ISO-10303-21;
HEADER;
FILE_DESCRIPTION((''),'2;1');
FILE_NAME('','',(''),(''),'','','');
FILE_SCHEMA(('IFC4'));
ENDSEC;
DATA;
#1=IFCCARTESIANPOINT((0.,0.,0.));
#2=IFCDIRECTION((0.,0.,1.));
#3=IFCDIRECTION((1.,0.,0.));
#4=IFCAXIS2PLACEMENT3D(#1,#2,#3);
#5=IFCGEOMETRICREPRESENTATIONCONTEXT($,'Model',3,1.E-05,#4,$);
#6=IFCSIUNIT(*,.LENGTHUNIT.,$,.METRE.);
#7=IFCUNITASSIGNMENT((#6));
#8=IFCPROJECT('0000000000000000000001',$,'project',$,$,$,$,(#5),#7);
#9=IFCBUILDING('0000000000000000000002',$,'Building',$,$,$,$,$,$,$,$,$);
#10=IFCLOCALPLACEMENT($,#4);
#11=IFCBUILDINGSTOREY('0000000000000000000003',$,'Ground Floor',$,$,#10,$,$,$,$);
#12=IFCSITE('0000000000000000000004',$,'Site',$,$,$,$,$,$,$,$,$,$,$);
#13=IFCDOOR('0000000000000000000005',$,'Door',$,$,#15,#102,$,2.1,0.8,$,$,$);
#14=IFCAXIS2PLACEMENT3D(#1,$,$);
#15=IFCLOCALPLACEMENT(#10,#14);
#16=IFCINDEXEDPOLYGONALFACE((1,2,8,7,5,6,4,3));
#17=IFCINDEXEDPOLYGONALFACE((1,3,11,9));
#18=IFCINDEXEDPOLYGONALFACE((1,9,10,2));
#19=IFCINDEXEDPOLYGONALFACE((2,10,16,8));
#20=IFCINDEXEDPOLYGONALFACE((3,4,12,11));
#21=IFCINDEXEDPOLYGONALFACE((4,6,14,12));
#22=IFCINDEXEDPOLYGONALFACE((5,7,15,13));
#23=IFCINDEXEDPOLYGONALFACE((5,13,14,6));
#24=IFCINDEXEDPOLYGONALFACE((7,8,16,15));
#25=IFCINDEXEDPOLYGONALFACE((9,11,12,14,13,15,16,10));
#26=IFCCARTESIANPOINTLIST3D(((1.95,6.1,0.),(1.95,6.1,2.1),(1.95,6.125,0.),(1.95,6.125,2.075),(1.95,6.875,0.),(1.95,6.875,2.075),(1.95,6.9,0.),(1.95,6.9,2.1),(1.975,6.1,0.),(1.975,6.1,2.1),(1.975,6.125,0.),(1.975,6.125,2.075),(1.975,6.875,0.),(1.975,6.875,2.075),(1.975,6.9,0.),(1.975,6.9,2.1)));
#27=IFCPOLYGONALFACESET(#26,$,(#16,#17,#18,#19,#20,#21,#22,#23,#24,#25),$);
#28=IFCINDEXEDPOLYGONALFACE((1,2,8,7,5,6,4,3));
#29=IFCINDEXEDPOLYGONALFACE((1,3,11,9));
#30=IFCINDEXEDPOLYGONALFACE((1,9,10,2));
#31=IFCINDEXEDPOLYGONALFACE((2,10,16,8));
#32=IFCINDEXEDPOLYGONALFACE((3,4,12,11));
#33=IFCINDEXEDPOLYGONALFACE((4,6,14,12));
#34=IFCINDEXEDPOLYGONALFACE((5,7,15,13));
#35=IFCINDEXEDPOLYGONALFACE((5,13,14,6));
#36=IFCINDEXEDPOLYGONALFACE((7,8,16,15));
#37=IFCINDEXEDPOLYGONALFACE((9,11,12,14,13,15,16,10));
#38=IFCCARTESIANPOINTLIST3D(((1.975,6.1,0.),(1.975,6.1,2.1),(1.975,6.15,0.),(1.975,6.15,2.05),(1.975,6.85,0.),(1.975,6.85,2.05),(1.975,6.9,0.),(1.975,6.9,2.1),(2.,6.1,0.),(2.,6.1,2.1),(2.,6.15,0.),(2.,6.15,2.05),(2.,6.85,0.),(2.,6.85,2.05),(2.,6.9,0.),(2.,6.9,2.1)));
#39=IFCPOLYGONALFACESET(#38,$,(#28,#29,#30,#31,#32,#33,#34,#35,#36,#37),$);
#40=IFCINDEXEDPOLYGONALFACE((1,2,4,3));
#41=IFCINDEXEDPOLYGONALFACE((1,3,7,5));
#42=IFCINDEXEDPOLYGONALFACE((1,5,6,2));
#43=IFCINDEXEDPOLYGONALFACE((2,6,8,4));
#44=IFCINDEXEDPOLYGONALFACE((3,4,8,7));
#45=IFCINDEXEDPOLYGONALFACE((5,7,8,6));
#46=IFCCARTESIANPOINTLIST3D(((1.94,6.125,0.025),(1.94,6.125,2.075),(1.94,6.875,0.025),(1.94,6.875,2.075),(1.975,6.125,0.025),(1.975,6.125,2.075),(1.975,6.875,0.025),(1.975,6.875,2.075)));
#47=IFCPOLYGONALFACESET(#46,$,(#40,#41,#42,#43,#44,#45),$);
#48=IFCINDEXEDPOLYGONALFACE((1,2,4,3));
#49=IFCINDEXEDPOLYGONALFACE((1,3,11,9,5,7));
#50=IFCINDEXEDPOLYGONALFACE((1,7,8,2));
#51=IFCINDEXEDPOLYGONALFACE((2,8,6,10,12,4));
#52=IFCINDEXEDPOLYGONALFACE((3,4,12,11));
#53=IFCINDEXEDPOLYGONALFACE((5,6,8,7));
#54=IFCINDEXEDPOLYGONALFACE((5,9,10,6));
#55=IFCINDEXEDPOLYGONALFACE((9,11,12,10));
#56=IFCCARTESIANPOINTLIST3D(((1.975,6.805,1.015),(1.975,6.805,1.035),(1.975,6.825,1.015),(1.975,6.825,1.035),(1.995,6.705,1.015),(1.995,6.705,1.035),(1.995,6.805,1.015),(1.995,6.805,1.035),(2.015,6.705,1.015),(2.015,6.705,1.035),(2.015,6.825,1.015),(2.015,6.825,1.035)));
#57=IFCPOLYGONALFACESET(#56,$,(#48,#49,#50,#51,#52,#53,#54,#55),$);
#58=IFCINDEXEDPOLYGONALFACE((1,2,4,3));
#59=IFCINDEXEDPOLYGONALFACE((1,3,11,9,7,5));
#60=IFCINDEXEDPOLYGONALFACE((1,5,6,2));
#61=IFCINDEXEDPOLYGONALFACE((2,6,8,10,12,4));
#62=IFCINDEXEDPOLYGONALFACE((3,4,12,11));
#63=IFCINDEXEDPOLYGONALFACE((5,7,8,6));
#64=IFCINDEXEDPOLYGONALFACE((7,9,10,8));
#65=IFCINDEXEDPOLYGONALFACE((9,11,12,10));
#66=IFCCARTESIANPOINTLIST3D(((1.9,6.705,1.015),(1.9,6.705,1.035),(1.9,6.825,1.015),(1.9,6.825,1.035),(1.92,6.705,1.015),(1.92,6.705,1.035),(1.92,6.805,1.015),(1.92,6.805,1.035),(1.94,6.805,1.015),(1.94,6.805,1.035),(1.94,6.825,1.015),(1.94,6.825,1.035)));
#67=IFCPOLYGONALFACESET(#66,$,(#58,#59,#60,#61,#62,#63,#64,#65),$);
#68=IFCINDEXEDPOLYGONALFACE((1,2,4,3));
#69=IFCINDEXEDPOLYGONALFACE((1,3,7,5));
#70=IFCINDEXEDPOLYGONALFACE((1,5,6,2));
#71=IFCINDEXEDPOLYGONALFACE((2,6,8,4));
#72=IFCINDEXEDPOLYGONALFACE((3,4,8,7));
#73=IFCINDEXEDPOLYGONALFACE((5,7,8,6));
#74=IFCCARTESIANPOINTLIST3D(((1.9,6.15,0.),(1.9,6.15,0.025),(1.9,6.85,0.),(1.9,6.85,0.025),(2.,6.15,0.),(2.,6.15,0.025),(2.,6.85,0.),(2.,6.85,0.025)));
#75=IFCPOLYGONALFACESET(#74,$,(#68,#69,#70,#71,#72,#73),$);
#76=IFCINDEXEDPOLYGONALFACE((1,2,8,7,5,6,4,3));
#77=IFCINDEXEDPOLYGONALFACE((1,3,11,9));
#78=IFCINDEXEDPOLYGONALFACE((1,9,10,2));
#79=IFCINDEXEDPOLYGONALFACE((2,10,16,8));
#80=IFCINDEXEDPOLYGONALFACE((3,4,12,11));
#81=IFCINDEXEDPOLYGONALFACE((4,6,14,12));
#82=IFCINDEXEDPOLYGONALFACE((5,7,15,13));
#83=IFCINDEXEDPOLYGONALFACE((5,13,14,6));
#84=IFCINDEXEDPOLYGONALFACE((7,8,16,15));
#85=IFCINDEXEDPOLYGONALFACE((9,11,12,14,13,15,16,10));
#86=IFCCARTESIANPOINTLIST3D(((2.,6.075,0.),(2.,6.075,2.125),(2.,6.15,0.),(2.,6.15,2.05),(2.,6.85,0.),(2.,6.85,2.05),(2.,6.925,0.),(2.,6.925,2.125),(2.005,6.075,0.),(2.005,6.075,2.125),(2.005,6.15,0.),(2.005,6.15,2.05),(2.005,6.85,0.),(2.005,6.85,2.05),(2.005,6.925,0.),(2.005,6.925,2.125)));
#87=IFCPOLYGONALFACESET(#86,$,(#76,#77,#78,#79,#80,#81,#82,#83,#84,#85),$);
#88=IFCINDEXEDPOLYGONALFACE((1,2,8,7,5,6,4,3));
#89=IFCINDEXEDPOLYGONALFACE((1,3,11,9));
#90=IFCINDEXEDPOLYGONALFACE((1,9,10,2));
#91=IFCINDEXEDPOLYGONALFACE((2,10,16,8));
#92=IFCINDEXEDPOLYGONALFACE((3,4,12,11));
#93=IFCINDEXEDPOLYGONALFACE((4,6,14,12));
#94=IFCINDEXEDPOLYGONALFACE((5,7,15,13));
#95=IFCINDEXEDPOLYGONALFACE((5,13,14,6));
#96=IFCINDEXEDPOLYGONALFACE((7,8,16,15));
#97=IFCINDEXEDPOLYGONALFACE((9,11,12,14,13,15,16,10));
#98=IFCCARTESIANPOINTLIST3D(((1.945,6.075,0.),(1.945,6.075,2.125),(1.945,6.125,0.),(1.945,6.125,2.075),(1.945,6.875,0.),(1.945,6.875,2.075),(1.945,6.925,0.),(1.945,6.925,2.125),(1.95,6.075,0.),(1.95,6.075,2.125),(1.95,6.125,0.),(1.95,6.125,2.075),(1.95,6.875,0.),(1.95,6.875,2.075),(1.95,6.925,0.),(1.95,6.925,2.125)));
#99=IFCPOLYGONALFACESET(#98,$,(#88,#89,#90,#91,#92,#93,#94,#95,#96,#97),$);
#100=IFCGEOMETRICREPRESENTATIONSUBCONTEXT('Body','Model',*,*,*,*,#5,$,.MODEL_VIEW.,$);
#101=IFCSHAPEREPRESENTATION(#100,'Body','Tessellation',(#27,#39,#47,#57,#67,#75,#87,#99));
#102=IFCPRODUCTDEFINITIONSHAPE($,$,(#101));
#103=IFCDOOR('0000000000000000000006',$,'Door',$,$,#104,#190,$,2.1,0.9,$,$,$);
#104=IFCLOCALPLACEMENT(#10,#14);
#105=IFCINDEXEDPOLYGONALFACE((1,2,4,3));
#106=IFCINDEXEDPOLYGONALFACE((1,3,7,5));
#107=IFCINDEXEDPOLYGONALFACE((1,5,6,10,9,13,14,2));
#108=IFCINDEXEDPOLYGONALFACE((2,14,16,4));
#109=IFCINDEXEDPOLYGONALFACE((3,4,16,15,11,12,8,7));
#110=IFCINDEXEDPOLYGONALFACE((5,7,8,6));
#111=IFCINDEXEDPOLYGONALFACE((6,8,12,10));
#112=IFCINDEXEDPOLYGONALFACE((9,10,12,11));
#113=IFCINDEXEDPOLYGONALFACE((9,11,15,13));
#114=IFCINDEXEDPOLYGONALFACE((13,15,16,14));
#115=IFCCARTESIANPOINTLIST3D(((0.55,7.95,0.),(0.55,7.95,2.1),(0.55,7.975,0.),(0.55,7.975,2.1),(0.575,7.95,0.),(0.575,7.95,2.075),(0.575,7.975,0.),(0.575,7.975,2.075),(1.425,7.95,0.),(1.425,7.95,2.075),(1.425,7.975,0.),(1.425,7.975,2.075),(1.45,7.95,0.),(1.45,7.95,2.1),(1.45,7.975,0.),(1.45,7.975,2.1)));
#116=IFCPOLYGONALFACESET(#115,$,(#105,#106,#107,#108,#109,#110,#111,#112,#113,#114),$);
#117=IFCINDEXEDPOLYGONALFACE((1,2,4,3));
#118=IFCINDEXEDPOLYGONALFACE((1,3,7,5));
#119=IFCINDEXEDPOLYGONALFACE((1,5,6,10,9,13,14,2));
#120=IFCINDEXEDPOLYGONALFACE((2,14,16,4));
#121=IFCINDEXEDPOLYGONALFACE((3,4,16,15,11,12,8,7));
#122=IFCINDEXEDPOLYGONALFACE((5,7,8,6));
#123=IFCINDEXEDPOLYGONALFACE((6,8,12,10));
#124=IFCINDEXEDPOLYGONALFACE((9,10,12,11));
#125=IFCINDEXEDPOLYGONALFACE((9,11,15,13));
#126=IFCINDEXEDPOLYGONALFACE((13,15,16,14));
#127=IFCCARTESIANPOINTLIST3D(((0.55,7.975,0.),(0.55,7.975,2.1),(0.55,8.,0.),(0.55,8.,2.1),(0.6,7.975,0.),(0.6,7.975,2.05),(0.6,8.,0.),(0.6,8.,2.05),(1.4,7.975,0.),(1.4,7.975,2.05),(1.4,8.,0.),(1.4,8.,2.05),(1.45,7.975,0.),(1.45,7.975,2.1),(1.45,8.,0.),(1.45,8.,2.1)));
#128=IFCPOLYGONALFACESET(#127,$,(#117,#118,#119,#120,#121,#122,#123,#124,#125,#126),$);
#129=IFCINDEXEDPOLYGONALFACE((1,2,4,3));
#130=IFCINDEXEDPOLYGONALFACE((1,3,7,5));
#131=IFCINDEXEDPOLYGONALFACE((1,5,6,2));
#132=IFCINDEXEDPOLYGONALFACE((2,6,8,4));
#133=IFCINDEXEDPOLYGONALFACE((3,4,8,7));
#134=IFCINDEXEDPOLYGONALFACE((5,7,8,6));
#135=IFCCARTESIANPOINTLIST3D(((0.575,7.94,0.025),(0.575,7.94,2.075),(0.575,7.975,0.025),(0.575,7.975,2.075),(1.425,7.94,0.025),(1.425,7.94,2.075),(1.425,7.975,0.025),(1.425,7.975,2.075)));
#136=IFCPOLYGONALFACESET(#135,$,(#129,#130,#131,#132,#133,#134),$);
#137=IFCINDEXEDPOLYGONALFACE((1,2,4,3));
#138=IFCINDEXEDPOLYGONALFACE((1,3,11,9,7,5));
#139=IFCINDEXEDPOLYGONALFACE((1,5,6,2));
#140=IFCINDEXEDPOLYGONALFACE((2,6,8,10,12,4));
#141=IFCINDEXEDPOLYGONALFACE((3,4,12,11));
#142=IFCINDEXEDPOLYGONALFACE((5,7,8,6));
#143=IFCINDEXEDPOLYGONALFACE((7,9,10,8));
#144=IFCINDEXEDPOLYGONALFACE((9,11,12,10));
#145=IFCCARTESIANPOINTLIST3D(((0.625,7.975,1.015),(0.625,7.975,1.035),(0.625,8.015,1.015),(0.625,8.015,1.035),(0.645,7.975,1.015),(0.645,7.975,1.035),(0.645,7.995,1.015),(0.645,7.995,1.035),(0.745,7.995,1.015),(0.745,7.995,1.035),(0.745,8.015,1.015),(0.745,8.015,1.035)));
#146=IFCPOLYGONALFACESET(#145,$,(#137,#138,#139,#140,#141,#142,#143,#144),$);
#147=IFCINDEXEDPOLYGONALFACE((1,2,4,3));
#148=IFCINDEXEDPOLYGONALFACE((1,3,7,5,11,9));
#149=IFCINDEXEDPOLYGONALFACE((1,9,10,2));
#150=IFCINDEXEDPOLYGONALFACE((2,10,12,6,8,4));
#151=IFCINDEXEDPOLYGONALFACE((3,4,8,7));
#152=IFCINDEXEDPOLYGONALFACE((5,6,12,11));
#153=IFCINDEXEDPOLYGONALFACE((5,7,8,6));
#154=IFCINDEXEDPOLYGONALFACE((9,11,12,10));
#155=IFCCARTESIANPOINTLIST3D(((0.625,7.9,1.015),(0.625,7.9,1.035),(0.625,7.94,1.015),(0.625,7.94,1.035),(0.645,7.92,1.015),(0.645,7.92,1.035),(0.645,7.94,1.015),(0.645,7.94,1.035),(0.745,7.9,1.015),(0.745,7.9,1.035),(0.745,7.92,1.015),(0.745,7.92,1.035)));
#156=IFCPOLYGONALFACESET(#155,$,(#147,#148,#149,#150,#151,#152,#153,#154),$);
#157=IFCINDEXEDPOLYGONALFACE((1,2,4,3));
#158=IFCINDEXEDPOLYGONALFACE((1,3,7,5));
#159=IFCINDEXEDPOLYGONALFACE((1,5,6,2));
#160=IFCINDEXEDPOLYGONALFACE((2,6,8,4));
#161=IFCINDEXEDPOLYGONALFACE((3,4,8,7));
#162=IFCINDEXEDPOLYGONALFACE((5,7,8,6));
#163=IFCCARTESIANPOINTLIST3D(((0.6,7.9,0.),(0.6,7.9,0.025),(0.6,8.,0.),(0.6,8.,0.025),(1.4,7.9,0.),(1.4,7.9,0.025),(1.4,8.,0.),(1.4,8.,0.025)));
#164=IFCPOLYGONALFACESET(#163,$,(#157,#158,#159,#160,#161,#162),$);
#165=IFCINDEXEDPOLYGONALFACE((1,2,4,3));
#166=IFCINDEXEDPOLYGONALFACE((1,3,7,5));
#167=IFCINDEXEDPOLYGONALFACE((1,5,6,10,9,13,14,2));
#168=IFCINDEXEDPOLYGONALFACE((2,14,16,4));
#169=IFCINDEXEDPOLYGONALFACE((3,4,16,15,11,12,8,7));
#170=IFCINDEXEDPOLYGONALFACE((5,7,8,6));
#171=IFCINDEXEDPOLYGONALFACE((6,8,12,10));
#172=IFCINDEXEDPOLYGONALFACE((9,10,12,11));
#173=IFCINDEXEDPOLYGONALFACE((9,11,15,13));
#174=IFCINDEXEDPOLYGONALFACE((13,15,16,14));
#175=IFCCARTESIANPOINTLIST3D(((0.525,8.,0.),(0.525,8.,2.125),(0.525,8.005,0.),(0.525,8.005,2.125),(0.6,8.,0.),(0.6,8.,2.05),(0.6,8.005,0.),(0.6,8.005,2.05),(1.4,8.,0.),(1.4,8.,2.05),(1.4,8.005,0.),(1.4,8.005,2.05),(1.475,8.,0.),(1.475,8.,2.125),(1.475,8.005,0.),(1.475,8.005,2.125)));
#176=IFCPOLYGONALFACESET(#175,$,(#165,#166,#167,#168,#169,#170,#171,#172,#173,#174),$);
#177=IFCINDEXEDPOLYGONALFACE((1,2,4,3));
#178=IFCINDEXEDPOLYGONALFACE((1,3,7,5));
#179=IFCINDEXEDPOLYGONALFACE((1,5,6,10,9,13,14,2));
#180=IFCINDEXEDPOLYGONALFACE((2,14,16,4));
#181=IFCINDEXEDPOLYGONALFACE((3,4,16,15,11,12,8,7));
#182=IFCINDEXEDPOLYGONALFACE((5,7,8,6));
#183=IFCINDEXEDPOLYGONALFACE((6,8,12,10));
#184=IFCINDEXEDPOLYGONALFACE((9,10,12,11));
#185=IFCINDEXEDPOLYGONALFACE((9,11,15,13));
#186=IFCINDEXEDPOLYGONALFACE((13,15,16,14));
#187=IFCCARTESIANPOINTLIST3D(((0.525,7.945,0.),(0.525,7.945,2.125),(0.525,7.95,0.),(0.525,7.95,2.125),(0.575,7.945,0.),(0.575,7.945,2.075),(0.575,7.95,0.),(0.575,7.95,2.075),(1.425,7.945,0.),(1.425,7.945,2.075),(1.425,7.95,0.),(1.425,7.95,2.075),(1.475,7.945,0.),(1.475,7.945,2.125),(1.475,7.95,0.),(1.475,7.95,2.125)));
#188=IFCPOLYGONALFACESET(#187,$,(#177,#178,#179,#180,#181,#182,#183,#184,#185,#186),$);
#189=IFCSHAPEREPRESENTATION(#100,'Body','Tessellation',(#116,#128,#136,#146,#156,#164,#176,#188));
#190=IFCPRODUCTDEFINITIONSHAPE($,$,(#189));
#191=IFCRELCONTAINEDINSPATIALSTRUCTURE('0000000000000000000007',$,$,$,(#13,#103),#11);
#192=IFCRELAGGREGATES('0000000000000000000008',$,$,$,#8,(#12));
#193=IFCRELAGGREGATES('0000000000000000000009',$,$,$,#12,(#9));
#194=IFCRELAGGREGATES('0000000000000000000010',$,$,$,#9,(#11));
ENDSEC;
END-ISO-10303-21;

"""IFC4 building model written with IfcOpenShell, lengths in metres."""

from ifc_helpers import new_model, si_unit, frame, origin_with_axes, place, context, subcontext, project, spatial, line, indexed_curve, outline, extrude, element, save


model = new_model("IFC4")

# Units and contexts
model_context = context("Model", 3, precision=1e-05, world=origin_with_axes())
body_context = subcontext(model_context, "Body", "Model", "MODEL_VIEW")
ifc_project = project(units=[si_unit("LENGTHUNIT", "METRE")], contexts=[model_context])

# Site, building, storey
site = spatial("IfcSite", under=ifc_project, Name="Site")
building = spatial("IfcBuilding", under=site, Name="Building")
storey_placement = place(None, origin_with_axes())
storey = spatial("IfcBuildingStorey", under=building, at=storey_placement, Name="Ground Floor")

# Doors
door_1_placement = place(storey_placement, frame((2.0, 6.1, 0.0), z_axis=(0.0, 0.0, 1.0), x_axis=(0.0, 1.0, 0.0)))
element("IfcDoor", 1, at=door_1_placement, inside=storey, Name="Door", OverallHeight=2.1, OverallWidth=0.8, context=body_context, shape_type="SweptSolid", body=[
    extrude(outline(indexed_curve([(0.0, 0.0), (0.0, 2.1), (0.8, 2.1), (0.8, 0.0), (0.775, 0.0), (0.775, 2.075), (0.025, 2.075), (0.025, 0.0)], segments=[line(1, 2, 3, 4, 5, 6, 7, 8, 1)])), frame((0.0, 0.025, 0.0), z_axis=(0.0, -1.0, 0.0), x_axis=(1.0, 0.0, 0.0)), (0.0, 0.0, -1.0), 0.025),
    extrude(outline(indexed_curve([(0.0, 0.0), (0.0, 2.1), (0.8, 2.1), (0.8, 0.0), (0.75, 0.0), (0.75, 2.05), (0.05, 2.05), (0.05, 0.0)], segments=[line(1, 2, 3, 4, 5, 6, 7, 8, 1)])), frame((0.0, 0.0, 0.0), z_axis=(0.0, -1.0, 0.0), x_axis=(1.0, 0.0, 0.0)), (0.0, 0.0, -1.0), 0.025),
    extrude(outline(indexed_curve([(0.0, 0.0), (0.75, 0.0), (0.75, 0.035), (0.0, 0.035)], segments=[line(1, 2, 3, 4, 1)])), frame((0.025, 0.025, 0.025), z_axis=(0.0, 0.0, 1.0), x_axis=(1.0, 0.0, 0.0)), (0.0, 0.0, 1.0), 2.05),
    extrude(outline(indexed_curve([(0.0, 0.0), (0.0, -0.04), (-0.12, -0.04), (-0.12, -0.02), (-0.02, -0.02), (-0.02, 0.0)], segments=[line(1, 2, 3, 4, 5, 6, 1)])), frame((0.725, 0.025, 1.015), z_axis=(0.0, 0.0, 1.0), x_axis=(1.0, 0.0, 0.0)), (0.0, 0.0, 1.0), 0.02),
    extrude(outline(indexed_curve([(0.0, 0.0), (0.0, 0.04), (-0.12, 0.04), (-0.12, 0.02), (-0.02, 0.02), (-0.02, 0.0)], segments=[line(1, 2, 3, 4, 5, 6, 1)])), frame((0.725, 0.06, 1.015), z_axis=(0.0, 0.0, 1.0), x_axis=(1.0, 0.0, 0.0)), (0.0, 0.0, 1.0), 0.02),
    extrude(outline(indexed_curve([(0.0, 0.0), (0.7, 0.0), (0.7, 0.1), (0.0, 0.1)], segments=[line(1, 2, 3, 4, 1)])), frame((0.05, 0.0, 0.0), z_axis=(0.0, 0.0, 1.0), x_axis=(1.0, 0.0, 0.0)), (0.0, 0.0, 1.0), 0.025),
    extrude(outline(indexed_curve([(0.0, 0.0), (0.0, 2.125), (0.85, 2.125), (0.85, 0.0), (0.775, 0.0), (0.775, 2.05), (0.075, 2.05), (0.075, 0.0)], segments=[line(1, 2, 3, 4, 5, 6, 7, 8, 1)])), frame((-0.025, -0.005, 0.0), z_axis=(0.0, -1.0, 0.0), x_axis=(1.0, 0.0, 0.0)), (0.0, 0.0, -1.0), 0.005),
    extrude(outline(indexed_curve([(0.0, 0.0), (0.0, 2.125), (0.85, 2.125), (0.85, 0.0), (0.8, 0.0), (0.8, 2.075), (0.05, 2.075), (0.05, 0.0)], segments=[line(1, 2, 3, 4, 5, 6, 7, 8, 1)])), frame((-0.025, 0.05, 0.0), z_axis=(0.0, -1.0, 0.0), x_axis=(1.0, 0.0, 0.0)), (0.0, 0.0, -1.0), 0.005),
])
door_2_placement = place(storey_placement, frame((1.45, 8.0, 0.0), z_axis=(0.0, 0.0, 1.0), x_axis=(-1.0, 0.0, 0.0)))
element("IfcDoor", 2, at=door_2_placement, inside=storey, Name="Door", OverallHeight=2.1, OverallWidth=0.9, context=body_context, shape_type="SweptSolid", body=[
    extrude(outline(indexed_curve([(0.0, 0.0), (0.0, 2.1), (0.9, 2.1), (0.9, 0.0), (0.875, 0.0), (0.875, 2.075), (0.025, 2.075), (0.025, 0.0)], segments=[line(1, 2, 3, 4, 5, 6, 7, 8, 1)])), frame((0.0, 0.025, 0.0), z_axis=(0.0, -1.0, 0.0), x_axis=(1.0, 0.0, 0.0)), (0.0, 0.0, -1.0), 0.025),
    extrude(outline(indexed_curve([(0.0, 0.0), (0.0, 2.1), (0.9, 2.1), (0.9, 0.0), (0.85, 0.0), (0.85, 2.05), (0.05, 2.05), (0.05, 0.0)], segments=[line(1, 2, 3, 4, 5, 6, 7, 8, 1)])), frame((0.0, 0.0, 0.0), z_axis=(0.0, -1.0, 0.0), x_axis=(1.0, 0.0, 0.0)), (0.0, 0.0, -1.0), 0.025),
    extrude(outline(indexed_curve([(0.0, 0.0), (0.85, 0.0), (0.85, 0.035), (0.0, 0.035)], segments=[line(1, 2, 3, 4, 1)])), frame((0.025, 0.025, 0.025), z_axis=(0.0, 0.0, 1.0), x_axis=(1.0, 0.0, 0.0)), (0.0, 0.0, 1.0), 2.05),
    extrude(outline(indexed_curve([(0.0, 0.0), (0.0, -0.04), (-0.12, -0.04), (-0.12, -0.02), (-0.02, -0.02), (-0.02, 0.0)], segments=[line(1, 2, 3, 4, 5, 6, 1)])), frame((0.825, 0.025, 1.015), z_axis=(0.0, 0.0, 1.0), x_axis=(1.0, 0.0, 0.0)), (0.0, 0.0, 1.0), 0.02),
    extrude(outline(indexed_curve([(0.0, 0.0), (0.0, 0.04), (-0.12, 0.04), (-0.12, 0.02), (-0.02, 0.02), (-0.02, 0.0)], segments=[line(1, 2, 3, 4, 5, 6, 1)])), frame((0.825, 0.06, 1.015), z_axis=(0.0, 0.0, 1.0), x_axis=(1.0, 0.0, 0.0)), (0.0, 0.0, 1.0), 0.02),
    extrude(outline(indexed_curve([(0.0, 0.0), (0.8, 0.0), (0.8, 0.1), (0.0, 0.1)], segments=[line(1, 2, 3, 4, 1)])), frame((0.05, 0.0, 0.0), z_axis=(0.0, 0.0, 1.0), x_axis=(1.0, 0.0, 0.0)), (0.0, 0.0, 1.0), 0.025),
    extrude(outline(indexed_curve([(0.0, 0.0), (0.0, 2.125), (0.95, 2.125), (0.95, 0.0), (0.875, 0.0), (0.875, 2.05), (0.075, 2.05), (0.075, 0.0)], segments=[line(1, 2, 3, 4, 5, 6, 7, 8, 1)])), frame((-0.025, -0.005, 0.0), z_axis=(0.0, -1.0, 0.0), x_axis=(1.0, 0.0, 0.0)), (0.0, 0.0, -1.0), 0.005),
    extrude(outline(indexed_curve([(0.0, 0.0), (0.0, 2.125), (0.95, 2.125), (0.95, 0.0), (0.9, 0.0), (0.9, 2.075), (0.05, 2.075), (0.05, 0.0)], segments=[line(1, 2, 3, 4, 5, 6, 7, 8, 1)])), frame((-0.025, 0.05, 0.0), z_axis=(0.0, -1.0, 0.0), x_axis=(1.0, 0.0, 0.0)), (0.0, 0.0, -1.0), 0.005),
])

save(model, "model.ifc")
